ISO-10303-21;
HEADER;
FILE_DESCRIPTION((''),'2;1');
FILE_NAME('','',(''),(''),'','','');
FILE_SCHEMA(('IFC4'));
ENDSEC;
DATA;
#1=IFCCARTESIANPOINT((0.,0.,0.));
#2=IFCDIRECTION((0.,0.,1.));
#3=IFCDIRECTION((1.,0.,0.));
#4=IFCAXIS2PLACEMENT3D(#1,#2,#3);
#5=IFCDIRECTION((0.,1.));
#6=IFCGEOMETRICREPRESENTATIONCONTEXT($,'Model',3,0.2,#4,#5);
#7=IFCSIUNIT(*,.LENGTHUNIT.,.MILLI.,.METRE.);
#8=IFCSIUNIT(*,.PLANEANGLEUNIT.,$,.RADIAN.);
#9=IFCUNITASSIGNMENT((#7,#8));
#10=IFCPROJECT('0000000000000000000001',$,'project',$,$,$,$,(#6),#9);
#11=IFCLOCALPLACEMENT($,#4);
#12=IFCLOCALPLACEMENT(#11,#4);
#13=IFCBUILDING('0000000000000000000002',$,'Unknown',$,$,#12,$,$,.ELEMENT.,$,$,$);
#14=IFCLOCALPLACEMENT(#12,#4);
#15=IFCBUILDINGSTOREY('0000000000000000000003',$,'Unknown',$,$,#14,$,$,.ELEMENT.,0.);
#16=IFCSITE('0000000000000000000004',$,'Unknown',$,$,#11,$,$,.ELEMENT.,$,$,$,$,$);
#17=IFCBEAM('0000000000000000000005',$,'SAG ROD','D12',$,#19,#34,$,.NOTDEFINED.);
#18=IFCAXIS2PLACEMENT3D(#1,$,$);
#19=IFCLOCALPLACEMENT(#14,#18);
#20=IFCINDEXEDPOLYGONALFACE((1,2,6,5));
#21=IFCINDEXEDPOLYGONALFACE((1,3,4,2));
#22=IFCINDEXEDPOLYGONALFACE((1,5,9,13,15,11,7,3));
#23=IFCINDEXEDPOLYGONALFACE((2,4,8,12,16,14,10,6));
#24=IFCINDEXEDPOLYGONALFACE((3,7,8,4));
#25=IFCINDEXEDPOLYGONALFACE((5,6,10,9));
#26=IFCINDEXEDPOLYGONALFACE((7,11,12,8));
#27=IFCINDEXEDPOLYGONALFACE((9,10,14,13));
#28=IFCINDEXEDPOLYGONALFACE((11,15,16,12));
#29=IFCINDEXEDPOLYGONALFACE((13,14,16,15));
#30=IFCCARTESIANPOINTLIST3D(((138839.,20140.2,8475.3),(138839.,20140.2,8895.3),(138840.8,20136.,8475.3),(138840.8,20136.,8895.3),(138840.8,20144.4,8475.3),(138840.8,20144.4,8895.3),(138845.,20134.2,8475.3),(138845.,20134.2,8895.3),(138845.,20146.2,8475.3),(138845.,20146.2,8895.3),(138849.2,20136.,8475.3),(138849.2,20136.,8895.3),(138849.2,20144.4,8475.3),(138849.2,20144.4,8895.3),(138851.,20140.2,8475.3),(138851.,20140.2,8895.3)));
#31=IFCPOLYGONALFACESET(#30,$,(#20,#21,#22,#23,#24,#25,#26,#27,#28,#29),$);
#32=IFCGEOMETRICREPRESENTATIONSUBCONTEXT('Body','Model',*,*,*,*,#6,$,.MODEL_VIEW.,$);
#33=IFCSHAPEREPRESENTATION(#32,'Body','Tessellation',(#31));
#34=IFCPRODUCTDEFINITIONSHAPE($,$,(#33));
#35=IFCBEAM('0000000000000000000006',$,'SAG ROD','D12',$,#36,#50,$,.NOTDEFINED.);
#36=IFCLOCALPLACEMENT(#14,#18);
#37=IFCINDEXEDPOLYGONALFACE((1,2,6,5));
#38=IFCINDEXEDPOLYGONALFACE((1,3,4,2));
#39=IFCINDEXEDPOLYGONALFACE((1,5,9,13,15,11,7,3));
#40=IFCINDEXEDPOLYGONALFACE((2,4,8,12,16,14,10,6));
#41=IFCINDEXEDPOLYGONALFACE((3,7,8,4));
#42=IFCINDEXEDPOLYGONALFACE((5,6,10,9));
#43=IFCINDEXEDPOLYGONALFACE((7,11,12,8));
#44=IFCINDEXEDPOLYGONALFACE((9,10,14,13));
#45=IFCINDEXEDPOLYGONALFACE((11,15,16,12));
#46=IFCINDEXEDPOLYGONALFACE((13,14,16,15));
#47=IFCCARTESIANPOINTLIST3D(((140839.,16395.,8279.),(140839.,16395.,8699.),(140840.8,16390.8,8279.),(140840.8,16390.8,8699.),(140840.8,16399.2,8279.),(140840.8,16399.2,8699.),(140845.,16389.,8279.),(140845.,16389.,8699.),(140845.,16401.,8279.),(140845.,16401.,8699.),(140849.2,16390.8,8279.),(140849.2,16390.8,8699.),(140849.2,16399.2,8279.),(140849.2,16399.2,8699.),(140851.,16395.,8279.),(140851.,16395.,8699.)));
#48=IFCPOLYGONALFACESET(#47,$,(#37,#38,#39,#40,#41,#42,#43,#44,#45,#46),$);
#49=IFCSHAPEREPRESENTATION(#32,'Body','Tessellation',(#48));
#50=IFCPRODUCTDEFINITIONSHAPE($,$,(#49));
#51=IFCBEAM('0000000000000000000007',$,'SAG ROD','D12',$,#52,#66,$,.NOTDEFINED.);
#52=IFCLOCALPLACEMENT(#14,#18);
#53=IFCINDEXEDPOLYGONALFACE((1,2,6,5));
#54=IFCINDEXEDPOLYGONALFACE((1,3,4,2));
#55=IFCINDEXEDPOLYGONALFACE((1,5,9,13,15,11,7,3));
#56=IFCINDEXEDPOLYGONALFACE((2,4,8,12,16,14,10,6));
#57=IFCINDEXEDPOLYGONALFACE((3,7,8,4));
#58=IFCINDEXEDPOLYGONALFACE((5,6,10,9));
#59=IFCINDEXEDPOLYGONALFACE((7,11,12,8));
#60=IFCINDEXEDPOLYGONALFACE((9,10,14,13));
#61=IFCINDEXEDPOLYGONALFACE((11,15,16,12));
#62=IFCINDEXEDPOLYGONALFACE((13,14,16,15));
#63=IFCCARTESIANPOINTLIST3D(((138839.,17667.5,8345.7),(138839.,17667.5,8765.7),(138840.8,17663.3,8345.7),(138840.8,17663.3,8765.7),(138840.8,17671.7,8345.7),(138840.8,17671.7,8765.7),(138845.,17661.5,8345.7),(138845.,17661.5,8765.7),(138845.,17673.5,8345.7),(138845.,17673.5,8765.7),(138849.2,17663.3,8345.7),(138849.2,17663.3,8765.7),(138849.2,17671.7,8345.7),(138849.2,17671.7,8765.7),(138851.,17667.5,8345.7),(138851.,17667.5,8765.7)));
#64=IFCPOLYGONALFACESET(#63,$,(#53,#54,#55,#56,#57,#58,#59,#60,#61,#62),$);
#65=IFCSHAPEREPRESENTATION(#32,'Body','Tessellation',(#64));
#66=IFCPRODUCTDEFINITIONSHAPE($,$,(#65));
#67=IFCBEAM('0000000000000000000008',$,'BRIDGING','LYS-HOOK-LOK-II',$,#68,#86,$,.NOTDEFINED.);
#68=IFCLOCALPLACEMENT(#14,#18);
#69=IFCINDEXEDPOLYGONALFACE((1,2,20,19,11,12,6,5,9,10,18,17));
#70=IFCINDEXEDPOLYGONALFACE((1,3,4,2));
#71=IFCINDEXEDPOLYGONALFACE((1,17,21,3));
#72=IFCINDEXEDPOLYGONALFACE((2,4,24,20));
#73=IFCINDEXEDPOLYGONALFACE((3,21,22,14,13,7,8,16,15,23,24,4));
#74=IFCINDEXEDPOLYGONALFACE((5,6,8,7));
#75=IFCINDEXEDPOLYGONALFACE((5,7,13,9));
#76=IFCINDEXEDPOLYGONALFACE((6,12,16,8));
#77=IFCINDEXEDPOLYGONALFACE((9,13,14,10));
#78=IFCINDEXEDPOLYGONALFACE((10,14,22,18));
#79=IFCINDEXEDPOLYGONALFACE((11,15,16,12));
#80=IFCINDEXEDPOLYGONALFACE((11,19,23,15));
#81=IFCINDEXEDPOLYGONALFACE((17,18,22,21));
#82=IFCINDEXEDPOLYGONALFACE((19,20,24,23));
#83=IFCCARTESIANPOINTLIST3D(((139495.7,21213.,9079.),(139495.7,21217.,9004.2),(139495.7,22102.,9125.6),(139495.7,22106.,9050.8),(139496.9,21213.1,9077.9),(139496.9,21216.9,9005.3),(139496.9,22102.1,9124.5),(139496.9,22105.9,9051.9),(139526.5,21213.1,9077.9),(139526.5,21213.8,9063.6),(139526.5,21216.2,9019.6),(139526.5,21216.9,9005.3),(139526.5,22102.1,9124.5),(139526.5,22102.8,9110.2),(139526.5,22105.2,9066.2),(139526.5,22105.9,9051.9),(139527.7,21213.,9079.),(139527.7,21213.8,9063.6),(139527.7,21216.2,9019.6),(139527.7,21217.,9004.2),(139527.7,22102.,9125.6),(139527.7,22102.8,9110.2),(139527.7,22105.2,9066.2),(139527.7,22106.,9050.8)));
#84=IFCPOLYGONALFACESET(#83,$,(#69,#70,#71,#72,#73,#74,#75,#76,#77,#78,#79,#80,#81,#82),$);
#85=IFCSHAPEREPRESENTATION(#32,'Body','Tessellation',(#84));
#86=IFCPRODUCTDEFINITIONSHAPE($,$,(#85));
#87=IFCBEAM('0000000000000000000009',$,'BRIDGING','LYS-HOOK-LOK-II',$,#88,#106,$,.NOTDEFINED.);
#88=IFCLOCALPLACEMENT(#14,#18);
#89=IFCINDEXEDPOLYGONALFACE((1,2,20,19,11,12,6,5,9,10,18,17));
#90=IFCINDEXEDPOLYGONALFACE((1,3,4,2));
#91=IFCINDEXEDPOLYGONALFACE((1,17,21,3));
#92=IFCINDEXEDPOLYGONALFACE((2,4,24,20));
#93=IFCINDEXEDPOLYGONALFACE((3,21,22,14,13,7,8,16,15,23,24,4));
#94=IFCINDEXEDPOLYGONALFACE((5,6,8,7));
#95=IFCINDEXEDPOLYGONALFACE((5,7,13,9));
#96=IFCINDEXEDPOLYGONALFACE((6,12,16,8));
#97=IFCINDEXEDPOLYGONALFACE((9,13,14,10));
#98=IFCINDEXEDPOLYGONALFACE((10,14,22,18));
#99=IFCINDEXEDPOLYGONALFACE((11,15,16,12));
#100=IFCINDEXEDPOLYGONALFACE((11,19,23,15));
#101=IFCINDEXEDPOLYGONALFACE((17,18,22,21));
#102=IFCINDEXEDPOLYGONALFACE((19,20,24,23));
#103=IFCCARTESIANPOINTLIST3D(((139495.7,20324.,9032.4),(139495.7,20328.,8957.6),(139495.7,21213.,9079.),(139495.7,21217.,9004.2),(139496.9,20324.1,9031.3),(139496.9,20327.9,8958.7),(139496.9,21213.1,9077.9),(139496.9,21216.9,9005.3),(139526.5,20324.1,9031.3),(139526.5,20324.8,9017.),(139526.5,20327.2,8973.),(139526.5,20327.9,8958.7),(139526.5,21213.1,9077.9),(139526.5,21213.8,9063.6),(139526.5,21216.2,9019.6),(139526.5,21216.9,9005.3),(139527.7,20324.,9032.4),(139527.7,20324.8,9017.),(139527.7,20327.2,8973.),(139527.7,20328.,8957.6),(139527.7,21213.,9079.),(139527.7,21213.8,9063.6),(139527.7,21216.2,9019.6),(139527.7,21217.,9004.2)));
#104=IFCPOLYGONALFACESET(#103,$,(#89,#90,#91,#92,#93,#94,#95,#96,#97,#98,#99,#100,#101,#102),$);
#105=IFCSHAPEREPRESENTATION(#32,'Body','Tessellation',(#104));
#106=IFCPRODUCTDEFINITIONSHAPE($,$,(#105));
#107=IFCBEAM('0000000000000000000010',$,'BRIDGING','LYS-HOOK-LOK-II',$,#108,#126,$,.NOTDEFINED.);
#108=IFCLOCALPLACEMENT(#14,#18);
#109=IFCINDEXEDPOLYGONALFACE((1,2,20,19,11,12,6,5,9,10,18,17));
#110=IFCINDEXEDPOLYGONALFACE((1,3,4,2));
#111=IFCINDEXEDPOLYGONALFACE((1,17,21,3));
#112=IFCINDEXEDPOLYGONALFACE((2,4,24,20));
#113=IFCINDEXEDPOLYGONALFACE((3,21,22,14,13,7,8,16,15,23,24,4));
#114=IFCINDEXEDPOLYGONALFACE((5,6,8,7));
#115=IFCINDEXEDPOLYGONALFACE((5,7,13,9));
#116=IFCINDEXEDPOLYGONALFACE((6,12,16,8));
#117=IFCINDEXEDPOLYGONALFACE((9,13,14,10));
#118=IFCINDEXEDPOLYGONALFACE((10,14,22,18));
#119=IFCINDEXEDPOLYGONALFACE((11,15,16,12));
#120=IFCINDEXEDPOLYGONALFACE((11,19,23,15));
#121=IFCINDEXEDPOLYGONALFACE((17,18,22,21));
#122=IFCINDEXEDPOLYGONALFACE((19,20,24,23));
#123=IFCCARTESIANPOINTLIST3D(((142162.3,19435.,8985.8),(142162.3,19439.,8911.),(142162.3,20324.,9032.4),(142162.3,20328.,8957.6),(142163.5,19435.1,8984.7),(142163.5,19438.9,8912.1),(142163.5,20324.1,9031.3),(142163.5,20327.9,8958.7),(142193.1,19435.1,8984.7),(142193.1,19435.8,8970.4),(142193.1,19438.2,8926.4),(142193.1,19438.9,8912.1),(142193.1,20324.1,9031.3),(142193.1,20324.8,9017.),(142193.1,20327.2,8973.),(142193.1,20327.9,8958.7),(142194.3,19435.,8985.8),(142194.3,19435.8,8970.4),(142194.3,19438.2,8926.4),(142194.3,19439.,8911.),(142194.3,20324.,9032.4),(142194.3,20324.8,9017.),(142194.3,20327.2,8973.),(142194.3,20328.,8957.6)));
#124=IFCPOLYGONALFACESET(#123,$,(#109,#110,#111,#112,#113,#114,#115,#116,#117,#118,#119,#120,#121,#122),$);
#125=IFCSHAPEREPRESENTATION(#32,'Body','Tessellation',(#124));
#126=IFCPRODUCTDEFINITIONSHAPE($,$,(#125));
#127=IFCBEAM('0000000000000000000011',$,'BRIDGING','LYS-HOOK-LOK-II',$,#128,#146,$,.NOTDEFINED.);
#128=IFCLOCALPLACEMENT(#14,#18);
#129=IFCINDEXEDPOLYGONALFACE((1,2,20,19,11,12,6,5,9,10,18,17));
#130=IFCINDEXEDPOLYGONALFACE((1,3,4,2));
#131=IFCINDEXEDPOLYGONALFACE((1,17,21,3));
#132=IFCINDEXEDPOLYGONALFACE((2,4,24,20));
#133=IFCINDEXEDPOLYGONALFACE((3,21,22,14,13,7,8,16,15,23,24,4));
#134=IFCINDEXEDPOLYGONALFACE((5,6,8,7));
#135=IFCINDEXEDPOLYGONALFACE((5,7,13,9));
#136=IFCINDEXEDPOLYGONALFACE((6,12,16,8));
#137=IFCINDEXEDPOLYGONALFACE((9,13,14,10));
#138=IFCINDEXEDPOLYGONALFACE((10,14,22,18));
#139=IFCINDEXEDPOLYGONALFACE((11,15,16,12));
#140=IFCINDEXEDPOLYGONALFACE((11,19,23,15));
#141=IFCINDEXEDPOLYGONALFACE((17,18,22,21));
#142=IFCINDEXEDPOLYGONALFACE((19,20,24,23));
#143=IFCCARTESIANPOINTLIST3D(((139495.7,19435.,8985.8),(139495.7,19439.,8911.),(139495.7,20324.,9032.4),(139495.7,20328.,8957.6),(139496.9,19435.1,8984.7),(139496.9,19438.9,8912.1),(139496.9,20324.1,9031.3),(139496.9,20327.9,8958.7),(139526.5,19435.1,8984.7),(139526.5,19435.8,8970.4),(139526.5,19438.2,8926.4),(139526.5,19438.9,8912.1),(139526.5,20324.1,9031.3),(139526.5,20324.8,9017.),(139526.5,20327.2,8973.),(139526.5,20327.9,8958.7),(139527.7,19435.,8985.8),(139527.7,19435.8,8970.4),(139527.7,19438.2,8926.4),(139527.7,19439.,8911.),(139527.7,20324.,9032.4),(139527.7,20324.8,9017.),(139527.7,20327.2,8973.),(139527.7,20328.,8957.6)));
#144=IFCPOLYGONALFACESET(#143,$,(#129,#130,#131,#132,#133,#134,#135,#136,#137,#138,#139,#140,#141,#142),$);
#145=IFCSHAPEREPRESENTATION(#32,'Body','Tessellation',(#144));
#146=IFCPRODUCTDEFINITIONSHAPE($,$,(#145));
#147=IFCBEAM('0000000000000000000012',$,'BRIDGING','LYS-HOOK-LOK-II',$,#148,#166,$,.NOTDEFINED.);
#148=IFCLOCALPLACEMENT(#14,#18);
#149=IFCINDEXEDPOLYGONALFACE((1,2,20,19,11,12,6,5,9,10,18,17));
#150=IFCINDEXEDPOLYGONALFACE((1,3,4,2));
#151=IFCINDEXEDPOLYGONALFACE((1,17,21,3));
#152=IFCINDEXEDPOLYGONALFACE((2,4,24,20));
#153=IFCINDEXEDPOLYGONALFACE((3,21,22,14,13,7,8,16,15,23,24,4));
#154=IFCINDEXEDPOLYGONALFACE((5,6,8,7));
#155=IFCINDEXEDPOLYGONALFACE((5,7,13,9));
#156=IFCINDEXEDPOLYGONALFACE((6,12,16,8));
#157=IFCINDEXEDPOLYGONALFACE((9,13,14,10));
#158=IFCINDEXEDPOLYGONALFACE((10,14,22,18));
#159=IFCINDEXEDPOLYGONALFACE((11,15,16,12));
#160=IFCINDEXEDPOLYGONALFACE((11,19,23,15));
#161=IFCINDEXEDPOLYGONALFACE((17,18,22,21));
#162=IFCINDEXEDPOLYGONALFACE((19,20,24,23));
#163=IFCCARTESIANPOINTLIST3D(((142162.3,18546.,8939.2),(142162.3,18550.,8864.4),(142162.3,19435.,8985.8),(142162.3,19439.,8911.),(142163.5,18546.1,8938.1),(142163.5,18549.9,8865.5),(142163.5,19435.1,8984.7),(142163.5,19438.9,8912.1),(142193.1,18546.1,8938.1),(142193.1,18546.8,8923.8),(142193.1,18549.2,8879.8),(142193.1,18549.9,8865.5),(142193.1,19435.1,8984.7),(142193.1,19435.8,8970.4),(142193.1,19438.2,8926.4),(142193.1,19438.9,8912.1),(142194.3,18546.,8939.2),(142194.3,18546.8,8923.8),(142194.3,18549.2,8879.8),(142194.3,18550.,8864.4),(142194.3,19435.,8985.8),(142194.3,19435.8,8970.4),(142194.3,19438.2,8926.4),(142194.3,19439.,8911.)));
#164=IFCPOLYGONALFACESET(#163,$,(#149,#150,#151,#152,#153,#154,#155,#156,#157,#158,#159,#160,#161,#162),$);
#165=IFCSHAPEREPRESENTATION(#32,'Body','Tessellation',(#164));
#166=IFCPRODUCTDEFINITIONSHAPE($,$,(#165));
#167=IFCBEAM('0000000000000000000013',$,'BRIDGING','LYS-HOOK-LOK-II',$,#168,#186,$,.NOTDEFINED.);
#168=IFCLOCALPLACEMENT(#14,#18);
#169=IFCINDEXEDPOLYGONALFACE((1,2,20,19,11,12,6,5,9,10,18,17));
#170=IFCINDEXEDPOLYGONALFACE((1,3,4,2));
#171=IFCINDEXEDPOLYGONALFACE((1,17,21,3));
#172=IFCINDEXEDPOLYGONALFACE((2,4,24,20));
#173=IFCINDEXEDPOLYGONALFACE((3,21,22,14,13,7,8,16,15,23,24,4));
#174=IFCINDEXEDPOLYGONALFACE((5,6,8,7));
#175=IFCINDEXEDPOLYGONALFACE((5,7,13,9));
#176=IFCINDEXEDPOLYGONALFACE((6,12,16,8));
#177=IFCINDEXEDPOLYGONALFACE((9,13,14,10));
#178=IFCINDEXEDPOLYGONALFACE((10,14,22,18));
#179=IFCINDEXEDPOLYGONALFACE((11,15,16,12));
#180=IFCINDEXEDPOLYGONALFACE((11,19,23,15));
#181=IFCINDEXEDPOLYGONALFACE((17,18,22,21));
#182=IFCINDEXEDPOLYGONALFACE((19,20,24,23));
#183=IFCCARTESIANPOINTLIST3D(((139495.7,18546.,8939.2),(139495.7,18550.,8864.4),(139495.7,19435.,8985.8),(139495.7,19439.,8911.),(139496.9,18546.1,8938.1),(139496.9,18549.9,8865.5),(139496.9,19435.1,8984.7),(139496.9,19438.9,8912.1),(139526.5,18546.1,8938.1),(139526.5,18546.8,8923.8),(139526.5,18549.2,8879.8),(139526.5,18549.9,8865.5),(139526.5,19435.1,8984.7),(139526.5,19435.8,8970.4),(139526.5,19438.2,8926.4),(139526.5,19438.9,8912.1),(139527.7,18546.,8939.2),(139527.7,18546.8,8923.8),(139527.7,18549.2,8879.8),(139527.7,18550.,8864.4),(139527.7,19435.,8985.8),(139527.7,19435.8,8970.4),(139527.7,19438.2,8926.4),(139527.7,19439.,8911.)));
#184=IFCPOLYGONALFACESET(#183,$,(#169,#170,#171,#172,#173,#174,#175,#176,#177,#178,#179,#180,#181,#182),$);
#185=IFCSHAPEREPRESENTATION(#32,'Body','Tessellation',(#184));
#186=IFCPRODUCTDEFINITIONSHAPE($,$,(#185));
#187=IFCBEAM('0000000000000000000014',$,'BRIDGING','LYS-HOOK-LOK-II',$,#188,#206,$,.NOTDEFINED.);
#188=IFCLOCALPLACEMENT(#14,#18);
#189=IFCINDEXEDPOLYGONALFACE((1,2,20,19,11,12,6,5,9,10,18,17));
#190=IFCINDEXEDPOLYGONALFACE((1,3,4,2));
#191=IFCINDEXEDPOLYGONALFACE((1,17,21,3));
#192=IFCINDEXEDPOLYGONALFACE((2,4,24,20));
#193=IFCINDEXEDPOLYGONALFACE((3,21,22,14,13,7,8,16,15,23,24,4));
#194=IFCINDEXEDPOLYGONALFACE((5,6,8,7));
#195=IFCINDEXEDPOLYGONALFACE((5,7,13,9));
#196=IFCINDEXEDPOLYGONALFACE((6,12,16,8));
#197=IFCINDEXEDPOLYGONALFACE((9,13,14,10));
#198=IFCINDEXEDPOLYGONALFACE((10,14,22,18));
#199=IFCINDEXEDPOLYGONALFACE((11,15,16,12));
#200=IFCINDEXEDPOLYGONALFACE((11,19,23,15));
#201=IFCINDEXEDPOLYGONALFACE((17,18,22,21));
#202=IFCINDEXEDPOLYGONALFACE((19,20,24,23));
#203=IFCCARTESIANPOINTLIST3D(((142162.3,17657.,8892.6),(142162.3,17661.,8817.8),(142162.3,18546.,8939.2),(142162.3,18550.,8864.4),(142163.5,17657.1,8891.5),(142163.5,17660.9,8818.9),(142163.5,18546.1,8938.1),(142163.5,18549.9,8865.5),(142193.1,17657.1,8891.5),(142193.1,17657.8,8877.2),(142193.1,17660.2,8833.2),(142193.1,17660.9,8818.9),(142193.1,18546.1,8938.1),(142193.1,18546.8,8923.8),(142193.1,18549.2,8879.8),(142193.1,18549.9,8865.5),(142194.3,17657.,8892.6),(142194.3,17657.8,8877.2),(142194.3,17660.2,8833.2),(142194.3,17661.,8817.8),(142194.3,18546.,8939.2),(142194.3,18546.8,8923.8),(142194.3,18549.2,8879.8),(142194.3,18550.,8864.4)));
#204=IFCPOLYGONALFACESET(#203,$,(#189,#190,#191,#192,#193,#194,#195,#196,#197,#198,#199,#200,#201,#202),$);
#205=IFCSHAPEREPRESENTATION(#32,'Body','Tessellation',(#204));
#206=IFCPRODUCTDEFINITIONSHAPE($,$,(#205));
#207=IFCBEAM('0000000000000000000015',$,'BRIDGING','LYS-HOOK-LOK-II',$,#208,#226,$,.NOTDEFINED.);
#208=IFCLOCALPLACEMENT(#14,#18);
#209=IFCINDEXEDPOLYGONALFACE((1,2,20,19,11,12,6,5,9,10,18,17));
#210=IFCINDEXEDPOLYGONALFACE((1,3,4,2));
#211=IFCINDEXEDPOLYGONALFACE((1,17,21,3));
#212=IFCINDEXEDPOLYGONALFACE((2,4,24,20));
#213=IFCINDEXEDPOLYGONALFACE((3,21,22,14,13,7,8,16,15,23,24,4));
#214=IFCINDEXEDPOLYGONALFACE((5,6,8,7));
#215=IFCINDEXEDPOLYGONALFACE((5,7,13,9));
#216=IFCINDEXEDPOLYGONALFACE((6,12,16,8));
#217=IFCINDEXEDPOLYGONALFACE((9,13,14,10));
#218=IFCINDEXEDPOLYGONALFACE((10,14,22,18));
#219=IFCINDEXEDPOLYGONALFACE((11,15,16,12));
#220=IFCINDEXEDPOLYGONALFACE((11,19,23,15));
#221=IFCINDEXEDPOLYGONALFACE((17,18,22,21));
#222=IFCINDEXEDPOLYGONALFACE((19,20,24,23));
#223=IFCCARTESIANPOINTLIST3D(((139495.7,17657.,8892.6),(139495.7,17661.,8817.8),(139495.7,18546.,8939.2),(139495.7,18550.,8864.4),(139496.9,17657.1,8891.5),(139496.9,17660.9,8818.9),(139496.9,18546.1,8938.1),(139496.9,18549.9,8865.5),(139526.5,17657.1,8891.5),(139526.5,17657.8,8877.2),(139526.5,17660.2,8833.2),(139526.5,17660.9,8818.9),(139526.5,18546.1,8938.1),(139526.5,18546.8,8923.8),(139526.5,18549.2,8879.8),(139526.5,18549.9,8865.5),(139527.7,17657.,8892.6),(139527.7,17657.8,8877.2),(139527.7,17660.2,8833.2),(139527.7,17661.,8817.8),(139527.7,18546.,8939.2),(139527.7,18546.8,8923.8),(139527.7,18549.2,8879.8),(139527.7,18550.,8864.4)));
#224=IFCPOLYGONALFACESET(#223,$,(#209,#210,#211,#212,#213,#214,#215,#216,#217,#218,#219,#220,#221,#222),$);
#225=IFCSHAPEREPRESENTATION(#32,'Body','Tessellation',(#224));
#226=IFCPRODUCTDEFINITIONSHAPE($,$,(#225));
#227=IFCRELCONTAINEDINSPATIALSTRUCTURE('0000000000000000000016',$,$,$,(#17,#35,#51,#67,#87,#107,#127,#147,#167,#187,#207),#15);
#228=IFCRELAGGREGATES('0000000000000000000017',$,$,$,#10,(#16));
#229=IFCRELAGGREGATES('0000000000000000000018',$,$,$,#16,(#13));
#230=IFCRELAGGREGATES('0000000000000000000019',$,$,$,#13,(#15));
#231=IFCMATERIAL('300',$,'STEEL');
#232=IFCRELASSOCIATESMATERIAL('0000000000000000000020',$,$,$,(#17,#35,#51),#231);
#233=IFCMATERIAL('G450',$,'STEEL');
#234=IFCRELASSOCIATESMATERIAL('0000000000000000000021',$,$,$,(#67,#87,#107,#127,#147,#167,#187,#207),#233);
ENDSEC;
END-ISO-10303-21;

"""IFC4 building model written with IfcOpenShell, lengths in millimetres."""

from ifc_helpers import new_model, si_unit, direction, frame, origin_with_axes, place, context, subcontext, project, spatial, line, indexed_curve, outline, extrude, material, element, save


model = new_model("IFC4")

# Units and contexts
model_context = context("Model", 3, precision=0.2, world=origin_with_axes(), true_north=direction((0.0, 1.0)))
body_context = subcontext(model_context, "Body", "Model", "MODEL_VIEW")
ifc_project = project(units=[si_unit("LENGTHUNIT", "METRE", prefix="MILLI"), si_unit("PLANEANGLEUNIT", "RADIAN")], contexts=[model_context])

# Site, building, storey
site_placement = place(None, origin_with_axes())
site = spatial("IfcSite", under=ifc_project, at=site_placement, Name="Unknown", CompositionType="ELEMENT")
building_placement = place(site_placement, origin_with_axes())
building = spatial("IfcBuilding", under=site, at=building_placement, Name="Unknown", CompositionType="ELEMENT")
storey_placement = place(building_placement, origin_with_axes())
storey = spatial("IfcBuildingStorey", under=building, at=storey_placement, Name="Unknown", CompositionType="ELEMENT", Elevation=0.0)

# Beams
ifc_material_1 = material(Name="300", Category="STEEL")
for number, where, z_axis, x_axis, name in (
    (1, (138845.0, 20140.2, 8895.3), (1.0, 0.0, 0.0), (0.0, 0.0, -1.0), "SAG ROD"),
    (2, (140845.0, 16395.0, 8699.0), (1.0, 0.0, 0.0), (0.0, 0.0, -1.0), "SAG ROD"),
    (3, (138845.0, 17667.5, 8765.7), (1.0, 0.0, 0.0), (0.0, 0.0, -1.0), "SAG ROD"),
):
    element("IfcBeam", number, at=place(storey_placement, frame(where, z_axis=z_axis, x_axis=x_axis)), inside=storey, material=ifc_material_1, Name=name, Description="D12", PredefinedType="NOTDEFINED", context=body_context, shape_type="SolidModel", body=[
        extrude(outline(indexed_curve([(6.0, 0.0), (4.2, 4.2), (0.0, 6.0), (-4.2, 4.2), (-6.0, 0.0), (-4.2, -4.2), (0.0, -6.0), (4.2, -4.2)], segments=[line(1, 2, 3, 4, 5, 6, 7, 8, 1)])), frame((0.0, 0.0, 0.0), z_axis=(-1.0, 0.0, 0.0), x_axis=(0.0, 0.0, 1.0)), (0.0, 0.0, -1.0), 420.0),
    ])
ifc_material_2 = material(Name="G450", Category="STEEL")
for number, where, z_axis, x_axis, name in (
    (4, (139511.7, 21215.0, 9041.6), (1.0, 0.0, 0.0), (0.0, 0.998629, 0.052347), "BRIDGING"),
    (5, (139511.7, 20326.0, 8995.0), (1.0, 0.0, 0.0), (0.0, 0.998629, 0.052347), "BRIDGING"),
    (6, (142178.3, 19437.0, 8948.4), (1.0, 0.0, 0.0), (0.0, 0.998629, 0.052347), "BRIDGING"),
    (7, (139511.7, 19437.0, 8948.4), (1.0, 0.0, 0.0), (0.0, 0.998629, 0.052347), "BRIDGING"),
    (8, (142178.3, 18548.0, 8901.8), (1.0, 0.0, 0.0), (0.0, 0.998629, 0.052347), "BRIDGING"),
    (9, (139511.7, 18548.0, 8901.8), (1.0, 0.0, 0.0), (0.0, 0.998629, 0.052347), "BRIDGING"),
    (10, (142178.3, 17659.0, 8855.2), (1.0, 0.0, 0.0), (0.0, 0.998629, 0.052347), "BRIDGING"),
    (11, (139511.7, 17659.0, 8855.2), (1.0, 0.0, 0.0), (0.0, 0.998629, 0.052347), "BRIDGING"),
):
    element("IfcBeam", number, at=place(storey_placement, frame(where, z_axis=z_axis, x_axis=x_axis)), inside=storey, material=ifc_material_2, Name=name, Description="LYS-HOOK-LOK-II", PredefinedType="NOTDEFINED", context=body_context, shape_type="SolidModel", body=[
        extrude(outline(indexed_curve([(16.0, -37.5), (16.0, -22.0), (14.8, -22.0), (14.8, -36.3), (-14.8, -36.3), (-14.8, 36.3), (14.8, 36.3), (14.8, 22.0), (16.0, 22.0), (16.0, 37.5), (-16.0, 37.5), (-16.0, -37.5)], segments=[line(1, 2, 3, 4, 5, 6, 7, 8, 9, 10, 11, 12, 1)])), frame((0.0, 0.0, 0.0), z_axis=(-1.0, 0.0, 0.0), x_axis=(0.0, 0.0, 1.0)), (0.0, 0.0, -1.0), 890.2),
    ])

save(model, "model.ifc")
